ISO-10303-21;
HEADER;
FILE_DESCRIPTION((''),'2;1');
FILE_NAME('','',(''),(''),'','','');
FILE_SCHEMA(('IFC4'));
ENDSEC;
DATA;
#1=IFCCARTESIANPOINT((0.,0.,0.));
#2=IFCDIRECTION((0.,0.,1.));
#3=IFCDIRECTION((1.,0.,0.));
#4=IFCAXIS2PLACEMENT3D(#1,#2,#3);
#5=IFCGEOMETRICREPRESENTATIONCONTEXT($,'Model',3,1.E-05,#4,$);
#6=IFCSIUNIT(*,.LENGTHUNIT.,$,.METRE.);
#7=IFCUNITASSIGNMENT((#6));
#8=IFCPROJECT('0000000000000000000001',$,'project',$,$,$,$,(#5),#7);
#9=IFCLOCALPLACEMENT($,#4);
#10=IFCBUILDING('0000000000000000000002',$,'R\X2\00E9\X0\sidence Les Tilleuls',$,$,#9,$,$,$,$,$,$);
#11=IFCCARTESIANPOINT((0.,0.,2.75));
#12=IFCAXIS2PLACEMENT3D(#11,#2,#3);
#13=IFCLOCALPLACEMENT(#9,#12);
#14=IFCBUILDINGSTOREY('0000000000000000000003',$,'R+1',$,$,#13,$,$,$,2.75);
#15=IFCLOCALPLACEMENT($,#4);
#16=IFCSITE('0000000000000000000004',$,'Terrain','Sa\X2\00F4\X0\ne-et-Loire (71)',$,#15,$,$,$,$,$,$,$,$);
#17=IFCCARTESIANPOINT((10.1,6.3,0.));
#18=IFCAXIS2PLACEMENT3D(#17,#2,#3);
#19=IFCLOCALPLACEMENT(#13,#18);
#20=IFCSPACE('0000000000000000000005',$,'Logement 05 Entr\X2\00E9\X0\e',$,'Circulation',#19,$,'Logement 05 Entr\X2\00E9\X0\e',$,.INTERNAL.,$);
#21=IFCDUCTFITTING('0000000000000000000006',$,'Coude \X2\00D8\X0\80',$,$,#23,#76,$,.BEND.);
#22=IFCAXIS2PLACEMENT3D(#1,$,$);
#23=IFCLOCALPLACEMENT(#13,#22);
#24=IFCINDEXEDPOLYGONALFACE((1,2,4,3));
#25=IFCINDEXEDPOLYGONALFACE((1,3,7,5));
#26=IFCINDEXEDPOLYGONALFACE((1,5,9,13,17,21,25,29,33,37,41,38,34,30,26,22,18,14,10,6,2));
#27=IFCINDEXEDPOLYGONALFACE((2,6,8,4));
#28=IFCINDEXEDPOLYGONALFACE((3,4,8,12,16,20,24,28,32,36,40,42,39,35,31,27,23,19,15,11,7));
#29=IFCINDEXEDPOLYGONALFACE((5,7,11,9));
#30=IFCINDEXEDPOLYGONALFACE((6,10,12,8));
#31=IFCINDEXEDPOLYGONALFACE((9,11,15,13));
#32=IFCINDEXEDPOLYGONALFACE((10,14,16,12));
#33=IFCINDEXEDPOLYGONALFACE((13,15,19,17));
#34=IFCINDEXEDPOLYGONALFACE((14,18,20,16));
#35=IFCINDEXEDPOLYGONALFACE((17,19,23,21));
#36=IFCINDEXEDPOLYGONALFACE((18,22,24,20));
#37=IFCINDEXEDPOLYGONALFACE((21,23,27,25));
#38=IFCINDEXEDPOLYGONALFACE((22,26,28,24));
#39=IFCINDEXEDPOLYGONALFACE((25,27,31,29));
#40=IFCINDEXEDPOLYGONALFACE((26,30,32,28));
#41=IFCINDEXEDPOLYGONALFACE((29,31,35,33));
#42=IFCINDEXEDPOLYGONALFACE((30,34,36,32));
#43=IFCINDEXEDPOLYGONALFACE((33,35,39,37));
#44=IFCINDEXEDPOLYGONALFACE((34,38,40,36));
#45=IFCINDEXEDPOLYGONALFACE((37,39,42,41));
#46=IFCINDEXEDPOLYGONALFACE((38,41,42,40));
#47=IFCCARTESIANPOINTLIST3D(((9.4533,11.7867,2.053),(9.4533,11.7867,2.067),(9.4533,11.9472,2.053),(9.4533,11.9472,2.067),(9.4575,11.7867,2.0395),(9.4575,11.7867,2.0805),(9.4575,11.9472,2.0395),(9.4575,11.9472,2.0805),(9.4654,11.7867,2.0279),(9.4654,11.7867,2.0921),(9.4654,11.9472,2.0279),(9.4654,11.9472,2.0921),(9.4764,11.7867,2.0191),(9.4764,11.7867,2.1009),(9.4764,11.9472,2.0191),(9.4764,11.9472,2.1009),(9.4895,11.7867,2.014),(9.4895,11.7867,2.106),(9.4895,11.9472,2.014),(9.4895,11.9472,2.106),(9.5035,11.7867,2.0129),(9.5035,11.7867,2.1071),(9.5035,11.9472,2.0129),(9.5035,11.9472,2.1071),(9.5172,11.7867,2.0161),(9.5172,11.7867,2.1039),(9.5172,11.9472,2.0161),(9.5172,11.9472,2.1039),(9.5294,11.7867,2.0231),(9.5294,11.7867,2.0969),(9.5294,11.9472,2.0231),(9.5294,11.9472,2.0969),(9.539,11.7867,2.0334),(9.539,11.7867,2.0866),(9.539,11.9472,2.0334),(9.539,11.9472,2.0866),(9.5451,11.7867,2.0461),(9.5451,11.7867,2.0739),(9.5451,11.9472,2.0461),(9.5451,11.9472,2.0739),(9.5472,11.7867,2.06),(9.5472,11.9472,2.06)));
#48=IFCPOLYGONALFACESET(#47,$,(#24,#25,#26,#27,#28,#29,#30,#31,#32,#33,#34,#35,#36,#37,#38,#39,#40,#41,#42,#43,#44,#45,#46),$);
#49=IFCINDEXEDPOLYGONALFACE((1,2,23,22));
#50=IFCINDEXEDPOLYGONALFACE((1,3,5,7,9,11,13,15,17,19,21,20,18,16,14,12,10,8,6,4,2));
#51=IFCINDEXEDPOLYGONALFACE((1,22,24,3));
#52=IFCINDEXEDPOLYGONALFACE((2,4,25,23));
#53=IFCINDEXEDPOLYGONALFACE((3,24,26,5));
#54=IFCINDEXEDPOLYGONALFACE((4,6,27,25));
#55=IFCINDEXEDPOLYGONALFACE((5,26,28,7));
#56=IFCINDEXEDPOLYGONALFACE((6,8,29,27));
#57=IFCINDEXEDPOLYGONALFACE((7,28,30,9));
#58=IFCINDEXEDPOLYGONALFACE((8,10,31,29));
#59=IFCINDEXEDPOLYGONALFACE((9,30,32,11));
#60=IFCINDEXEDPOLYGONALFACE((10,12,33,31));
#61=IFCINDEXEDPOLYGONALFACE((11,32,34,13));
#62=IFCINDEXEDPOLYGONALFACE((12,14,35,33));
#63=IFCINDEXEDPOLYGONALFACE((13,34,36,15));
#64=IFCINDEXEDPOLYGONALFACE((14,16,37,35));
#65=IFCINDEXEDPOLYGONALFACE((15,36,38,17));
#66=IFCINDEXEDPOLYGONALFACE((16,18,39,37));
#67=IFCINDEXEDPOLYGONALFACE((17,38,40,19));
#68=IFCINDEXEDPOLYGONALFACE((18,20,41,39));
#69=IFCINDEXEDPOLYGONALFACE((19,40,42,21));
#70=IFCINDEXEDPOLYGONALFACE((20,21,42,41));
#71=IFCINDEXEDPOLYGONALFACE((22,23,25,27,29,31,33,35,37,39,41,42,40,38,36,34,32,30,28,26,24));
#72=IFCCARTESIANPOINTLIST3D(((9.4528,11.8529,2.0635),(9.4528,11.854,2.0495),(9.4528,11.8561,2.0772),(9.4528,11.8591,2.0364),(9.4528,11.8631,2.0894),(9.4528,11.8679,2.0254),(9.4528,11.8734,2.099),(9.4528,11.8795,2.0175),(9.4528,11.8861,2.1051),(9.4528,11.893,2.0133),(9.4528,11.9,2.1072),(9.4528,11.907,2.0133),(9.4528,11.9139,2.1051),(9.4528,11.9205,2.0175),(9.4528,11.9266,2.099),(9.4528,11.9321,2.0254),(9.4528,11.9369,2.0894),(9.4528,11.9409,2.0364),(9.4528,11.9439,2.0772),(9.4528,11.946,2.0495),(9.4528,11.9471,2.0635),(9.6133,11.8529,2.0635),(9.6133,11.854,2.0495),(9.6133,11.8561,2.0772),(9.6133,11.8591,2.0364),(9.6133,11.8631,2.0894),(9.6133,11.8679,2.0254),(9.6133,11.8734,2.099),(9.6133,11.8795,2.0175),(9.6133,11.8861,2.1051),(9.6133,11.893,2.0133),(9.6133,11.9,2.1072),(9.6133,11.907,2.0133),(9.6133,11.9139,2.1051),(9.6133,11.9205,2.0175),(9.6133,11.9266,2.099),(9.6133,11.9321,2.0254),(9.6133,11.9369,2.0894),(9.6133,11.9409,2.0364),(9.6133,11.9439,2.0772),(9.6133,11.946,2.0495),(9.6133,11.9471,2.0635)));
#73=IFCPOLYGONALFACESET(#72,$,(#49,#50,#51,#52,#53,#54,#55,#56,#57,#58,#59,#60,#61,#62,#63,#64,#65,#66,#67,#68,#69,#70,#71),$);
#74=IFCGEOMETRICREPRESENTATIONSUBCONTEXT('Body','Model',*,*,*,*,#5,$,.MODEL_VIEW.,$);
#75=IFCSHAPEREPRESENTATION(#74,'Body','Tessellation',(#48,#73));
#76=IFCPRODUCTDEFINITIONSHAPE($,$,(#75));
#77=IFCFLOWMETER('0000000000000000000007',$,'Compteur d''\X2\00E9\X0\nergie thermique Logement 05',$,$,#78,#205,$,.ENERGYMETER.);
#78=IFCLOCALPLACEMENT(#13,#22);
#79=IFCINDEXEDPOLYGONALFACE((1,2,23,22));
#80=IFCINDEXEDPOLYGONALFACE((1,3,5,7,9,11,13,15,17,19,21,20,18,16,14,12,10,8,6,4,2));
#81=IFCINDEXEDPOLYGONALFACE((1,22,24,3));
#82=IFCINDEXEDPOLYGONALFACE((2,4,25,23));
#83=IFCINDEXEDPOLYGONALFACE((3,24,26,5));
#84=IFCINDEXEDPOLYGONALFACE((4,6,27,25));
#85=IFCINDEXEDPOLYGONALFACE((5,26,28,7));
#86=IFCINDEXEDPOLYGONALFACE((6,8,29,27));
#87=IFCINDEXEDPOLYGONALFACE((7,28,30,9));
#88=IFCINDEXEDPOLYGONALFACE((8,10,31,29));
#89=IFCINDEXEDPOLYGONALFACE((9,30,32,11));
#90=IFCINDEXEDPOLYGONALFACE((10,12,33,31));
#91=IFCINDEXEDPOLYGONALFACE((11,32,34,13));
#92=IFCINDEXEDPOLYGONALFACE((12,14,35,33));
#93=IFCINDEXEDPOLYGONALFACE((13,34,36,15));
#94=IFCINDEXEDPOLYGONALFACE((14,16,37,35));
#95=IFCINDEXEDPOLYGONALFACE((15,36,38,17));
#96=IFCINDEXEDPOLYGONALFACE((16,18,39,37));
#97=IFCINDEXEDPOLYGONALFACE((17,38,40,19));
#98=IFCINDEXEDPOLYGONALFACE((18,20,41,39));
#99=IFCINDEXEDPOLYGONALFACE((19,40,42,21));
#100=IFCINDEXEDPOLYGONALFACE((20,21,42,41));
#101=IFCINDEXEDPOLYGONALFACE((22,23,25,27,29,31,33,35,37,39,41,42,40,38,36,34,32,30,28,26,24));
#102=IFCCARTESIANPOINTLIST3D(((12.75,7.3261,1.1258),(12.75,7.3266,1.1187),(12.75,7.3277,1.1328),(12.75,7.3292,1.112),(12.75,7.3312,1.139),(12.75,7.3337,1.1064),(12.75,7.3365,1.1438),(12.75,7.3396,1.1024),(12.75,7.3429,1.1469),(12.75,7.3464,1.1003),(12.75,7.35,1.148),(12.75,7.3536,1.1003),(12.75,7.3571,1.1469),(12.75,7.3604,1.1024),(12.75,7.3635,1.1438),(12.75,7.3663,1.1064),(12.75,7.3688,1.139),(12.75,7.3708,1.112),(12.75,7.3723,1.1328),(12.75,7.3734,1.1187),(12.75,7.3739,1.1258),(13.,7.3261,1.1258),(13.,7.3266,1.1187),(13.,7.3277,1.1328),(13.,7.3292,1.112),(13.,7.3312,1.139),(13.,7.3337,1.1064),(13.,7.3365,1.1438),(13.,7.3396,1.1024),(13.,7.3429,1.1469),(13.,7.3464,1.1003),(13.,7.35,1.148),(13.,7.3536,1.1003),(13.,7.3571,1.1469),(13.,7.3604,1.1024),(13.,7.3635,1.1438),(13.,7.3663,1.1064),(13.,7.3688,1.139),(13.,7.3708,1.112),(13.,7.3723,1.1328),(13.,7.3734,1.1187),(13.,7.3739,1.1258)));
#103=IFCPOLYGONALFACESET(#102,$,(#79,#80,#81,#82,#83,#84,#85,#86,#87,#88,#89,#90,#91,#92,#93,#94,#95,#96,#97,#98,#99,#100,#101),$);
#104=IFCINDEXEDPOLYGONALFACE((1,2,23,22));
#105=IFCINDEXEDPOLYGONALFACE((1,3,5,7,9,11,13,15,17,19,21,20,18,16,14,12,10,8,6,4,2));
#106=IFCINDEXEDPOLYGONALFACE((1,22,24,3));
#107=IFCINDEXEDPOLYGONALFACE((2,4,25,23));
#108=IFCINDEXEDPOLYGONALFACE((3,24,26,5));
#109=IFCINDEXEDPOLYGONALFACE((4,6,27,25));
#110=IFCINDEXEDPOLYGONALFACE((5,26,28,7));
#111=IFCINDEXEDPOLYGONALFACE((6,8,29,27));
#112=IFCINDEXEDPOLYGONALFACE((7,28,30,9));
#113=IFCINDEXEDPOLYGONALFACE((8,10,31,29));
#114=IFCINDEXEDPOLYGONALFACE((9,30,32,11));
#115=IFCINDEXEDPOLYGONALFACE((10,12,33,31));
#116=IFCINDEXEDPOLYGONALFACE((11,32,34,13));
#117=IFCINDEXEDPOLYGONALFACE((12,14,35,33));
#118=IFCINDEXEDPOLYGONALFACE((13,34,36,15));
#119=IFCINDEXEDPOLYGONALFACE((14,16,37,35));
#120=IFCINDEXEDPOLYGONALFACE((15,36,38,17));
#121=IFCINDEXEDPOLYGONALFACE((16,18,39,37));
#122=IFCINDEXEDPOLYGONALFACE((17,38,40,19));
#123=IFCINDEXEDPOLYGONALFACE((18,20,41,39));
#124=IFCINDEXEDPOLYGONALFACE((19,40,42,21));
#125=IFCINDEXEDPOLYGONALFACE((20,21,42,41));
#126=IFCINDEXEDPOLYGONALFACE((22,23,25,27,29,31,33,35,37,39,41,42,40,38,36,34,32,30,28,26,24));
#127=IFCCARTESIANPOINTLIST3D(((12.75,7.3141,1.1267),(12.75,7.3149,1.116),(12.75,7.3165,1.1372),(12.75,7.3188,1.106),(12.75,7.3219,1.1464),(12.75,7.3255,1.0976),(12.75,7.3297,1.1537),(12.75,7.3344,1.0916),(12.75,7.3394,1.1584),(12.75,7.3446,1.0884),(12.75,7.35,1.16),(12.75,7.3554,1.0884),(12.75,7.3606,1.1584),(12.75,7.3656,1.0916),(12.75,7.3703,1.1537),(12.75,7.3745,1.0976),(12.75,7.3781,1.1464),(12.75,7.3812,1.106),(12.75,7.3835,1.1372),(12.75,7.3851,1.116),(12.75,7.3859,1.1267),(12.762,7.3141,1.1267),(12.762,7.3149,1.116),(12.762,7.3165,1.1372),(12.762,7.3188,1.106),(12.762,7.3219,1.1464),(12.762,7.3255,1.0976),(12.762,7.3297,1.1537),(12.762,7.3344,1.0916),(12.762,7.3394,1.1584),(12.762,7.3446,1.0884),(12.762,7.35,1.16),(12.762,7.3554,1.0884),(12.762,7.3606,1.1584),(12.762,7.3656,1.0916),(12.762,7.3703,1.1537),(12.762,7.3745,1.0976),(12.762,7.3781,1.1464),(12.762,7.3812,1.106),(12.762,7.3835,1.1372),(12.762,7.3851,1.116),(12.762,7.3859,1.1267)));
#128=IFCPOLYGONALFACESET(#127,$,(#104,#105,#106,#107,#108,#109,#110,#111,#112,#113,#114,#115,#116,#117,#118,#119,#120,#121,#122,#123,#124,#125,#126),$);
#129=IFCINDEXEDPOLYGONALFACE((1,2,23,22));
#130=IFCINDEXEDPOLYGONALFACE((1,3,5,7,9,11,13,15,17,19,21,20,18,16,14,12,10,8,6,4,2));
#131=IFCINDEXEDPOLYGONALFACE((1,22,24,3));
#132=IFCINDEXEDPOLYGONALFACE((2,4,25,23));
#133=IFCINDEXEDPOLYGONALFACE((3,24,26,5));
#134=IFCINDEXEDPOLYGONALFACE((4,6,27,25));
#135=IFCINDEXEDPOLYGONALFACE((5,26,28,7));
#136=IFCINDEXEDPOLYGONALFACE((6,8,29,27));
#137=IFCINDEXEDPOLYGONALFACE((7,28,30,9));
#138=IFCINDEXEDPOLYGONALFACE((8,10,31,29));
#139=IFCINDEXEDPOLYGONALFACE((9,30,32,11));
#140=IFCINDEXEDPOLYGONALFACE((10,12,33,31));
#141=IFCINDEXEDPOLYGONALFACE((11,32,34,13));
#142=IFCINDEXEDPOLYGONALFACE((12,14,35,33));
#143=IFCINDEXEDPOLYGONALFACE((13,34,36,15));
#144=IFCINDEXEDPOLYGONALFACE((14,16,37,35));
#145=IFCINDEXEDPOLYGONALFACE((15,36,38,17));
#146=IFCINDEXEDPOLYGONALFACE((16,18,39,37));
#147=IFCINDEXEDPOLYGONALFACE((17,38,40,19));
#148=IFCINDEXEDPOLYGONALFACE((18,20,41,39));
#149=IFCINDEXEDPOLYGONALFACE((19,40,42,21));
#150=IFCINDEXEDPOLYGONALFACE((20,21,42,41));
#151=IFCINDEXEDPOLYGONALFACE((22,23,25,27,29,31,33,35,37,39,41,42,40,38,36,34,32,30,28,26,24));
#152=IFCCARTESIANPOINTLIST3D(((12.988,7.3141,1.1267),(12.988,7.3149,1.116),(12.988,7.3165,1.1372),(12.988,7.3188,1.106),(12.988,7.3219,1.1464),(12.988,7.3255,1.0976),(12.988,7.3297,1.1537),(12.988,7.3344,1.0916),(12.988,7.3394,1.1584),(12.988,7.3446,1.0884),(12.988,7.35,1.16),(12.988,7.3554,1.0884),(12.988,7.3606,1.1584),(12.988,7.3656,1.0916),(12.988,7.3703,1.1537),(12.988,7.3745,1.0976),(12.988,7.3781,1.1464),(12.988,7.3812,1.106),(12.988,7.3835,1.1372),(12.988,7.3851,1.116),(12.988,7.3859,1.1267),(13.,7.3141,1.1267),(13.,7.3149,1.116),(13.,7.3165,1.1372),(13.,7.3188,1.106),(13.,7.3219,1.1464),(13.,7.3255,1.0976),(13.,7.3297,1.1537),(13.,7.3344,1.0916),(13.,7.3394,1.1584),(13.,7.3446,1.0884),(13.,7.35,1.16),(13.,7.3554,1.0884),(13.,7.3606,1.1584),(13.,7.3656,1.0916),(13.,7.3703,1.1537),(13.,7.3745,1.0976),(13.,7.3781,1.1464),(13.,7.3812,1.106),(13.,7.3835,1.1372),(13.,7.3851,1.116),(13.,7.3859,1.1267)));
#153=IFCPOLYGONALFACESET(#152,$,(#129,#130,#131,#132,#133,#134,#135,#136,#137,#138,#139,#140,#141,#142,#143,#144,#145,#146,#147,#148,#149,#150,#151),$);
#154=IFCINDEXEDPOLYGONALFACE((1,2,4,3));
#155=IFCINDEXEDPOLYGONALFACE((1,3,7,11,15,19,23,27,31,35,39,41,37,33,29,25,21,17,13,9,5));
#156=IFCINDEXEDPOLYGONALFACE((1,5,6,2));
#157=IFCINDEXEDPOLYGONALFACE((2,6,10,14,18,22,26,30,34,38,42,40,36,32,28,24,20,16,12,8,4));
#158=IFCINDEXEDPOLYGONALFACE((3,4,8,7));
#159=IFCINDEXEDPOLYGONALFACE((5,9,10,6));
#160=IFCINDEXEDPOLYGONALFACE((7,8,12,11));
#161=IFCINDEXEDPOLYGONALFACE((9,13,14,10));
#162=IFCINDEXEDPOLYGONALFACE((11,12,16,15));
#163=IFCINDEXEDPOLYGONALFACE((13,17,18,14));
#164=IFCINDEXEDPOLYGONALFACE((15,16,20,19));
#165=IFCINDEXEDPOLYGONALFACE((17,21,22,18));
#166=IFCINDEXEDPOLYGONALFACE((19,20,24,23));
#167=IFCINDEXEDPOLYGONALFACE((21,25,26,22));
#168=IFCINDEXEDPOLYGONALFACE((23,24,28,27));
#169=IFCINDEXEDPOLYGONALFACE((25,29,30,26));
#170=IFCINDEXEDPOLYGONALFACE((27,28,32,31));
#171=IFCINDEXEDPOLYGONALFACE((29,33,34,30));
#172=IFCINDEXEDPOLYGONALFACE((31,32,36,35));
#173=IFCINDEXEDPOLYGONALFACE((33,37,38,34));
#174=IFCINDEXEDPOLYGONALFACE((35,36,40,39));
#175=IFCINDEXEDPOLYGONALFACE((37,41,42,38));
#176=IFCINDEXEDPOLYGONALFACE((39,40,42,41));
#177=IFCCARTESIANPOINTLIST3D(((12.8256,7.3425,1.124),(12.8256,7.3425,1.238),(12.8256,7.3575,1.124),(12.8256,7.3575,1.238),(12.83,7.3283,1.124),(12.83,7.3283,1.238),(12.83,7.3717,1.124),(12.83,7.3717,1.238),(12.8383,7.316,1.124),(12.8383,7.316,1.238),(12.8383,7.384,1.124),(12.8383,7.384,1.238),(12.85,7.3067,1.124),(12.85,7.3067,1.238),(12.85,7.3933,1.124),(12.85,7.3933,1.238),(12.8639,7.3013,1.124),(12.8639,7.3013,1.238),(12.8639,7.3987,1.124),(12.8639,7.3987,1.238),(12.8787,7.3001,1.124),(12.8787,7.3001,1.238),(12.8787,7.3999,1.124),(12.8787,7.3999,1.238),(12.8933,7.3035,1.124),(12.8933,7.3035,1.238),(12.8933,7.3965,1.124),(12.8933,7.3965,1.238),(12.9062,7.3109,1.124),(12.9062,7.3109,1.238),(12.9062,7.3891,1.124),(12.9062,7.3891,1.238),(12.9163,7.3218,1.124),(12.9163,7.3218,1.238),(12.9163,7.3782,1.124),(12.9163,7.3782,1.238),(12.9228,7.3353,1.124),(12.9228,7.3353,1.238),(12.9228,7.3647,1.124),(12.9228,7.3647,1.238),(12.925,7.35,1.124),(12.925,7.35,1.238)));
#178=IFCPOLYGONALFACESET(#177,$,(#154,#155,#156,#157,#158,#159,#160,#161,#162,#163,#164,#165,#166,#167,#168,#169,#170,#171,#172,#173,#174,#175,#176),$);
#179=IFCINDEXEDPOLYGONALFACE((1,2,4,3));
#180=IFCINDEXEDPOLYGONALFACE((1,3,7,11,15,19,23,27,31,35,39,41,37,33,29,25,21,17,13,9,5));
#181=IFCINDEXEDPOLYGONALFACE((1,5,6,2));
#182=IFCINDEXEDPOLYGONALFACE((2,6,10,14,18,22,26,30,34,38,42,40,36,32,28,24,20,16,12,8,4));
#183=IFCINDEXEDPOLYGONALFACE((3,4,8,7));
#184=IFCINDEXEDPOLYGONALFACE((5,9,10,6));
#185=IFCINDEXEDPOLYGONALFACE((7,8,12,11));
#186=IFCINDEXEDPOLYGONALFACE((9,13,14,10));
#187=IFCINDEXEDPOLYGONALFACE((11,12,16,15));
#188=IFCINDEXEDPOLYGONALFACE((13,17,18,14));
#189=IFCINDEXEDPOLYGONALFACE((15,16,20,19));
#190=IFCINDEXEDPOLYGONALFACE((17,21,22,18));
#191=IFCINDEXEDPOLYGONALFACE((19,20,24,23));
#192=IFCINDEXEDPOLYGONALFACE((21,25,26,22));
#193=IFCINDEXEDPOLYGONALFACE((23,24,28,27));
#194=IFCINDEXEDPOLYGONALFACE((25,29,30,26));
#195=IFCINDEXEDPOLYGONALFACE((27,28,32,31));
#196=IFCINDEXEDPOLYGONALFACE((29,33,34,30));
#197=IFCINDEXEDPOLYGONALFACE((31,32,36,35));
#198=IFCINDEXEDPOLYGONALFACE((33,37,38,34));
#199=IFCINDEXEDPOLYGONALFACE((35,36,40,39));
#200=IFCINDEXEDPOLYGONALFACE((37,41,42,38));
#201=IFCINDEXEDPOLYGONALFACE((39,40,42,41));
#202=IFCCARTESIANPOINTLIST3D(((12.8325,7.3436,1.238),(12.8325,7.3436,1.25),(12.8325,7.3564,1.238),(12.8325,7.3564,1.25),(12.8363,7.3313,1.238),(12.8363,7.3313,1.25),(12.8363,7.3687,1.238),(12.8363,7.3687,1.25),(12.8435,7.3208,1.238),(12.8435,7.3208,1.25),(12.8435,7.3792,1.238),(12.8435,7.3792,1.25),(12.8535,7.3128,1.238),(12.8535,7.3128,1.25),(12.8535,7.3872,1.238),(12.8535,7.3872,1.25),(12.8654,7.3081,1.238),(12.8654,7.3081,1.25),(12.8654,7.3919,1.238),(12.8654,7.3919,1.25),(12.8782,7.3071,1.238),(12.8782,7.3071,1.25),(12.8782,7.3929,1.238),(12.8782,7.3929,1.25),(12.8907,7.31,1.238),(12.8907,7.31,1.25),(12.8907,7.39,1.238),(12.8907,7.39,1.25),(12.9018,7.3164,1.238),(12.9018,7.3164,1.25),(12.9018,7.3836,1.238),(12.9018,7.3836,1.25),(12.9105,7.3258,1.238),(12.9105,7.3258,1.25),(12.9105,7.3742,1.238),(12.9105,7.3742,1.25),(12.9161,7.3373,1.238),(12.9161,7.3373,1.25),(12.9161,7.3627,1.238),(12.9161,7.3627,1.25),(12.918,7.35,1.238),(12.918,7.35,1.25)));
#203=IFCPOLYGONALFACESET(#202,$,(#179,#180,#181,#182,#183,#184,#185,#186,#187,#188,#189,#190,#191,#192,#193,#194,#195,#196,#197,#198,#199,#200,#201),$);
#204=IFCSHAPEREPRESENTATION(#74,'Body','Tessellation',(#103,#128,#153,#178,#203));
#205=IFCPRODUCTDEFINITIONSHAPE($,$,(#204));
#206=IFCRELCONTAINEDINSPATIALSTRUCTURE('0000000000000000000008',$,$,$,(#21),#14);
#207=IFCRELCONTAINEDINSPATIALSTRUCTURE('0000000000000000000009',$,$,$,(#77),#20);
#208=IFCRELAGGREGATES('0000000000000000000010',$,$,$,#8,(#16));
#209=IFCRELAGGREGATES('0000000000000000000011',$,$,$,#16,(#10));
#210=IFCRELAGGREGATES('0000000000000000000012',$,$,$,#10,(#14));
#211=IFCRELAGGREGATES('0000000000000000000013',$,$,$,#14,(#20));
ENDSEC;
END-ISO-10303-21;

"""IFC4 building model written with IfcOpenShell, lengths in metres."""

from ifc_helpers import new_model, si_unit, frame, origin_with_axes, place, context, subcontext, project, spatial, circle, extrude, element, save


model = new_model("IFC4")

# Units and contexts
model_context = context("Model", 3, precision=1e-05, world=origin_with_axes())
body_context = subcontext(model_context, "Body", "Model", "MODEL_VIEW")
ifc_project = project(units=[si_unit("LENGTHUNIT", "METRE")], contexts=[model_context])

# Site, building, storey
site_placement = place(None, origin_with_axes())
site = spatial("IfcSite", under=ifc_project, at=site_placement, Name="Terrain", Description="Saône-et-Loire (71)")
building_placement = place(None, origin_with_axes())
building = spatial("IfcBuilding", under=site, at=building_placement, Name="Résidence Les Tilleuls")
storey_placement = place(building_placement, frame((0.0, 0.0, 2.75), z_axis=(0.0, 0.0, 1.0), x_axis=(1.0, 0.0, 0.0)))
storey = spatial("IfcBuildingStorey", under=building, at=storey_placement, Name="R+1", Elevation=2.75)

# Duct fitting
duct_fitting_1_placement = place(storey_placement, frame((9.5, 11.9, 2.06), z_axis=(0.0, 0.0, 1.0), x_axis=(1.0, 0.0, 0.0)))
element("IfcDuctFitting", 1, at=duct_fitting_1_placement, inside=storey, Name="Coude Ø80", PredefinedType="BEND", context=body_context, shape_type="SweptSolid", body=[
    extrude(circle(Radius=0.0472), frame((0.0, 0.0472, 0.0), z_axis=(0.0, -1.0, 0.0), x_axis=(1.0, 0.0, 0.0)), (0.0, 0.0, 1.0), 0.1605),
    extrude(circle(Radius=0.0472), frame((-0.0472, 0.0, 0.0), z_axis=(1.0, 0.0, 0.0), x_axis=(0.0, 0.0, 1.0)), (0.0, 0.0, 1.0), 0.1605),
])

# Shared definitions
space_1_placement = place(storey_placement, frame((10.1, 6.3, 0.0), z_axis=(0.0, 0.0, 1.0), x_axis=(1.0, 0.0, 0.0)))
space_1 = spatial("IfcSpace", under=storey, at=space_1_placement, Name="Logement 05 Entrée", ObjectType="Circulation", LongName="Logement 05 Entrée", PredefinedType="INTERNAL")

# Flow meter
flow_meter_placement = place(space_1_placement, frame((2.65, 1.0, 1.1), z_axis=(0.0, 0.0, 1.0), x_axis=(1.0, 0.0, 0.0)))
element("IfcFlowMeter", 2, at=flow_meter_placement, inside=space_1, Name="Compteur d'énergie thermique Logement 05", PredefinedType="ENERGYMETER", context=body_context, shape_type="SweptSolid", body=[
    extrude(circle(Radius=0.024), frame((0.0, 0.05, 0.024), z_axis=(1.0, 0.0, 0.0), x_axis=(0.0, 0.0, 1.0)), (0.0, 0.0, 1.0), 0.25),
    extrude(circle(Radius=0.036), frame((0.0, 0.05, 0.024), z_axis=(1.0, 0.0, 0.0), x_axis=(0.0, 0.0, 1.0)), (0.0, 0.0, 1.0), 0.012),
    extrude(circle(Radius=0.036), frame((0.238, 0.05, 0.024), z_axis=(1.0, 0.0, 0.0), x_axis=(0.0, 0.0, 1.0)), (0.0, 0.0, 1.0), 0.012),
    extrude(circle(Radius=0.05), frame((0.125, 0.05, 0.024), z_axis=(0.0, 0.0, 1.0), x_axis=(1.0, 0.0, 0.0)), (0.0, 0.0, 1.0), 0.114),
    extrude(circle(Radius=0.043), frame((0.125, 0.05, 0.138), z_axis=(0.0, 0.0, 1.0), x_axis=(1.0, 0.0, 0.0)), (0.0, 0.0, 1.0), 0.012),
])

save(model, "model.ifc")
